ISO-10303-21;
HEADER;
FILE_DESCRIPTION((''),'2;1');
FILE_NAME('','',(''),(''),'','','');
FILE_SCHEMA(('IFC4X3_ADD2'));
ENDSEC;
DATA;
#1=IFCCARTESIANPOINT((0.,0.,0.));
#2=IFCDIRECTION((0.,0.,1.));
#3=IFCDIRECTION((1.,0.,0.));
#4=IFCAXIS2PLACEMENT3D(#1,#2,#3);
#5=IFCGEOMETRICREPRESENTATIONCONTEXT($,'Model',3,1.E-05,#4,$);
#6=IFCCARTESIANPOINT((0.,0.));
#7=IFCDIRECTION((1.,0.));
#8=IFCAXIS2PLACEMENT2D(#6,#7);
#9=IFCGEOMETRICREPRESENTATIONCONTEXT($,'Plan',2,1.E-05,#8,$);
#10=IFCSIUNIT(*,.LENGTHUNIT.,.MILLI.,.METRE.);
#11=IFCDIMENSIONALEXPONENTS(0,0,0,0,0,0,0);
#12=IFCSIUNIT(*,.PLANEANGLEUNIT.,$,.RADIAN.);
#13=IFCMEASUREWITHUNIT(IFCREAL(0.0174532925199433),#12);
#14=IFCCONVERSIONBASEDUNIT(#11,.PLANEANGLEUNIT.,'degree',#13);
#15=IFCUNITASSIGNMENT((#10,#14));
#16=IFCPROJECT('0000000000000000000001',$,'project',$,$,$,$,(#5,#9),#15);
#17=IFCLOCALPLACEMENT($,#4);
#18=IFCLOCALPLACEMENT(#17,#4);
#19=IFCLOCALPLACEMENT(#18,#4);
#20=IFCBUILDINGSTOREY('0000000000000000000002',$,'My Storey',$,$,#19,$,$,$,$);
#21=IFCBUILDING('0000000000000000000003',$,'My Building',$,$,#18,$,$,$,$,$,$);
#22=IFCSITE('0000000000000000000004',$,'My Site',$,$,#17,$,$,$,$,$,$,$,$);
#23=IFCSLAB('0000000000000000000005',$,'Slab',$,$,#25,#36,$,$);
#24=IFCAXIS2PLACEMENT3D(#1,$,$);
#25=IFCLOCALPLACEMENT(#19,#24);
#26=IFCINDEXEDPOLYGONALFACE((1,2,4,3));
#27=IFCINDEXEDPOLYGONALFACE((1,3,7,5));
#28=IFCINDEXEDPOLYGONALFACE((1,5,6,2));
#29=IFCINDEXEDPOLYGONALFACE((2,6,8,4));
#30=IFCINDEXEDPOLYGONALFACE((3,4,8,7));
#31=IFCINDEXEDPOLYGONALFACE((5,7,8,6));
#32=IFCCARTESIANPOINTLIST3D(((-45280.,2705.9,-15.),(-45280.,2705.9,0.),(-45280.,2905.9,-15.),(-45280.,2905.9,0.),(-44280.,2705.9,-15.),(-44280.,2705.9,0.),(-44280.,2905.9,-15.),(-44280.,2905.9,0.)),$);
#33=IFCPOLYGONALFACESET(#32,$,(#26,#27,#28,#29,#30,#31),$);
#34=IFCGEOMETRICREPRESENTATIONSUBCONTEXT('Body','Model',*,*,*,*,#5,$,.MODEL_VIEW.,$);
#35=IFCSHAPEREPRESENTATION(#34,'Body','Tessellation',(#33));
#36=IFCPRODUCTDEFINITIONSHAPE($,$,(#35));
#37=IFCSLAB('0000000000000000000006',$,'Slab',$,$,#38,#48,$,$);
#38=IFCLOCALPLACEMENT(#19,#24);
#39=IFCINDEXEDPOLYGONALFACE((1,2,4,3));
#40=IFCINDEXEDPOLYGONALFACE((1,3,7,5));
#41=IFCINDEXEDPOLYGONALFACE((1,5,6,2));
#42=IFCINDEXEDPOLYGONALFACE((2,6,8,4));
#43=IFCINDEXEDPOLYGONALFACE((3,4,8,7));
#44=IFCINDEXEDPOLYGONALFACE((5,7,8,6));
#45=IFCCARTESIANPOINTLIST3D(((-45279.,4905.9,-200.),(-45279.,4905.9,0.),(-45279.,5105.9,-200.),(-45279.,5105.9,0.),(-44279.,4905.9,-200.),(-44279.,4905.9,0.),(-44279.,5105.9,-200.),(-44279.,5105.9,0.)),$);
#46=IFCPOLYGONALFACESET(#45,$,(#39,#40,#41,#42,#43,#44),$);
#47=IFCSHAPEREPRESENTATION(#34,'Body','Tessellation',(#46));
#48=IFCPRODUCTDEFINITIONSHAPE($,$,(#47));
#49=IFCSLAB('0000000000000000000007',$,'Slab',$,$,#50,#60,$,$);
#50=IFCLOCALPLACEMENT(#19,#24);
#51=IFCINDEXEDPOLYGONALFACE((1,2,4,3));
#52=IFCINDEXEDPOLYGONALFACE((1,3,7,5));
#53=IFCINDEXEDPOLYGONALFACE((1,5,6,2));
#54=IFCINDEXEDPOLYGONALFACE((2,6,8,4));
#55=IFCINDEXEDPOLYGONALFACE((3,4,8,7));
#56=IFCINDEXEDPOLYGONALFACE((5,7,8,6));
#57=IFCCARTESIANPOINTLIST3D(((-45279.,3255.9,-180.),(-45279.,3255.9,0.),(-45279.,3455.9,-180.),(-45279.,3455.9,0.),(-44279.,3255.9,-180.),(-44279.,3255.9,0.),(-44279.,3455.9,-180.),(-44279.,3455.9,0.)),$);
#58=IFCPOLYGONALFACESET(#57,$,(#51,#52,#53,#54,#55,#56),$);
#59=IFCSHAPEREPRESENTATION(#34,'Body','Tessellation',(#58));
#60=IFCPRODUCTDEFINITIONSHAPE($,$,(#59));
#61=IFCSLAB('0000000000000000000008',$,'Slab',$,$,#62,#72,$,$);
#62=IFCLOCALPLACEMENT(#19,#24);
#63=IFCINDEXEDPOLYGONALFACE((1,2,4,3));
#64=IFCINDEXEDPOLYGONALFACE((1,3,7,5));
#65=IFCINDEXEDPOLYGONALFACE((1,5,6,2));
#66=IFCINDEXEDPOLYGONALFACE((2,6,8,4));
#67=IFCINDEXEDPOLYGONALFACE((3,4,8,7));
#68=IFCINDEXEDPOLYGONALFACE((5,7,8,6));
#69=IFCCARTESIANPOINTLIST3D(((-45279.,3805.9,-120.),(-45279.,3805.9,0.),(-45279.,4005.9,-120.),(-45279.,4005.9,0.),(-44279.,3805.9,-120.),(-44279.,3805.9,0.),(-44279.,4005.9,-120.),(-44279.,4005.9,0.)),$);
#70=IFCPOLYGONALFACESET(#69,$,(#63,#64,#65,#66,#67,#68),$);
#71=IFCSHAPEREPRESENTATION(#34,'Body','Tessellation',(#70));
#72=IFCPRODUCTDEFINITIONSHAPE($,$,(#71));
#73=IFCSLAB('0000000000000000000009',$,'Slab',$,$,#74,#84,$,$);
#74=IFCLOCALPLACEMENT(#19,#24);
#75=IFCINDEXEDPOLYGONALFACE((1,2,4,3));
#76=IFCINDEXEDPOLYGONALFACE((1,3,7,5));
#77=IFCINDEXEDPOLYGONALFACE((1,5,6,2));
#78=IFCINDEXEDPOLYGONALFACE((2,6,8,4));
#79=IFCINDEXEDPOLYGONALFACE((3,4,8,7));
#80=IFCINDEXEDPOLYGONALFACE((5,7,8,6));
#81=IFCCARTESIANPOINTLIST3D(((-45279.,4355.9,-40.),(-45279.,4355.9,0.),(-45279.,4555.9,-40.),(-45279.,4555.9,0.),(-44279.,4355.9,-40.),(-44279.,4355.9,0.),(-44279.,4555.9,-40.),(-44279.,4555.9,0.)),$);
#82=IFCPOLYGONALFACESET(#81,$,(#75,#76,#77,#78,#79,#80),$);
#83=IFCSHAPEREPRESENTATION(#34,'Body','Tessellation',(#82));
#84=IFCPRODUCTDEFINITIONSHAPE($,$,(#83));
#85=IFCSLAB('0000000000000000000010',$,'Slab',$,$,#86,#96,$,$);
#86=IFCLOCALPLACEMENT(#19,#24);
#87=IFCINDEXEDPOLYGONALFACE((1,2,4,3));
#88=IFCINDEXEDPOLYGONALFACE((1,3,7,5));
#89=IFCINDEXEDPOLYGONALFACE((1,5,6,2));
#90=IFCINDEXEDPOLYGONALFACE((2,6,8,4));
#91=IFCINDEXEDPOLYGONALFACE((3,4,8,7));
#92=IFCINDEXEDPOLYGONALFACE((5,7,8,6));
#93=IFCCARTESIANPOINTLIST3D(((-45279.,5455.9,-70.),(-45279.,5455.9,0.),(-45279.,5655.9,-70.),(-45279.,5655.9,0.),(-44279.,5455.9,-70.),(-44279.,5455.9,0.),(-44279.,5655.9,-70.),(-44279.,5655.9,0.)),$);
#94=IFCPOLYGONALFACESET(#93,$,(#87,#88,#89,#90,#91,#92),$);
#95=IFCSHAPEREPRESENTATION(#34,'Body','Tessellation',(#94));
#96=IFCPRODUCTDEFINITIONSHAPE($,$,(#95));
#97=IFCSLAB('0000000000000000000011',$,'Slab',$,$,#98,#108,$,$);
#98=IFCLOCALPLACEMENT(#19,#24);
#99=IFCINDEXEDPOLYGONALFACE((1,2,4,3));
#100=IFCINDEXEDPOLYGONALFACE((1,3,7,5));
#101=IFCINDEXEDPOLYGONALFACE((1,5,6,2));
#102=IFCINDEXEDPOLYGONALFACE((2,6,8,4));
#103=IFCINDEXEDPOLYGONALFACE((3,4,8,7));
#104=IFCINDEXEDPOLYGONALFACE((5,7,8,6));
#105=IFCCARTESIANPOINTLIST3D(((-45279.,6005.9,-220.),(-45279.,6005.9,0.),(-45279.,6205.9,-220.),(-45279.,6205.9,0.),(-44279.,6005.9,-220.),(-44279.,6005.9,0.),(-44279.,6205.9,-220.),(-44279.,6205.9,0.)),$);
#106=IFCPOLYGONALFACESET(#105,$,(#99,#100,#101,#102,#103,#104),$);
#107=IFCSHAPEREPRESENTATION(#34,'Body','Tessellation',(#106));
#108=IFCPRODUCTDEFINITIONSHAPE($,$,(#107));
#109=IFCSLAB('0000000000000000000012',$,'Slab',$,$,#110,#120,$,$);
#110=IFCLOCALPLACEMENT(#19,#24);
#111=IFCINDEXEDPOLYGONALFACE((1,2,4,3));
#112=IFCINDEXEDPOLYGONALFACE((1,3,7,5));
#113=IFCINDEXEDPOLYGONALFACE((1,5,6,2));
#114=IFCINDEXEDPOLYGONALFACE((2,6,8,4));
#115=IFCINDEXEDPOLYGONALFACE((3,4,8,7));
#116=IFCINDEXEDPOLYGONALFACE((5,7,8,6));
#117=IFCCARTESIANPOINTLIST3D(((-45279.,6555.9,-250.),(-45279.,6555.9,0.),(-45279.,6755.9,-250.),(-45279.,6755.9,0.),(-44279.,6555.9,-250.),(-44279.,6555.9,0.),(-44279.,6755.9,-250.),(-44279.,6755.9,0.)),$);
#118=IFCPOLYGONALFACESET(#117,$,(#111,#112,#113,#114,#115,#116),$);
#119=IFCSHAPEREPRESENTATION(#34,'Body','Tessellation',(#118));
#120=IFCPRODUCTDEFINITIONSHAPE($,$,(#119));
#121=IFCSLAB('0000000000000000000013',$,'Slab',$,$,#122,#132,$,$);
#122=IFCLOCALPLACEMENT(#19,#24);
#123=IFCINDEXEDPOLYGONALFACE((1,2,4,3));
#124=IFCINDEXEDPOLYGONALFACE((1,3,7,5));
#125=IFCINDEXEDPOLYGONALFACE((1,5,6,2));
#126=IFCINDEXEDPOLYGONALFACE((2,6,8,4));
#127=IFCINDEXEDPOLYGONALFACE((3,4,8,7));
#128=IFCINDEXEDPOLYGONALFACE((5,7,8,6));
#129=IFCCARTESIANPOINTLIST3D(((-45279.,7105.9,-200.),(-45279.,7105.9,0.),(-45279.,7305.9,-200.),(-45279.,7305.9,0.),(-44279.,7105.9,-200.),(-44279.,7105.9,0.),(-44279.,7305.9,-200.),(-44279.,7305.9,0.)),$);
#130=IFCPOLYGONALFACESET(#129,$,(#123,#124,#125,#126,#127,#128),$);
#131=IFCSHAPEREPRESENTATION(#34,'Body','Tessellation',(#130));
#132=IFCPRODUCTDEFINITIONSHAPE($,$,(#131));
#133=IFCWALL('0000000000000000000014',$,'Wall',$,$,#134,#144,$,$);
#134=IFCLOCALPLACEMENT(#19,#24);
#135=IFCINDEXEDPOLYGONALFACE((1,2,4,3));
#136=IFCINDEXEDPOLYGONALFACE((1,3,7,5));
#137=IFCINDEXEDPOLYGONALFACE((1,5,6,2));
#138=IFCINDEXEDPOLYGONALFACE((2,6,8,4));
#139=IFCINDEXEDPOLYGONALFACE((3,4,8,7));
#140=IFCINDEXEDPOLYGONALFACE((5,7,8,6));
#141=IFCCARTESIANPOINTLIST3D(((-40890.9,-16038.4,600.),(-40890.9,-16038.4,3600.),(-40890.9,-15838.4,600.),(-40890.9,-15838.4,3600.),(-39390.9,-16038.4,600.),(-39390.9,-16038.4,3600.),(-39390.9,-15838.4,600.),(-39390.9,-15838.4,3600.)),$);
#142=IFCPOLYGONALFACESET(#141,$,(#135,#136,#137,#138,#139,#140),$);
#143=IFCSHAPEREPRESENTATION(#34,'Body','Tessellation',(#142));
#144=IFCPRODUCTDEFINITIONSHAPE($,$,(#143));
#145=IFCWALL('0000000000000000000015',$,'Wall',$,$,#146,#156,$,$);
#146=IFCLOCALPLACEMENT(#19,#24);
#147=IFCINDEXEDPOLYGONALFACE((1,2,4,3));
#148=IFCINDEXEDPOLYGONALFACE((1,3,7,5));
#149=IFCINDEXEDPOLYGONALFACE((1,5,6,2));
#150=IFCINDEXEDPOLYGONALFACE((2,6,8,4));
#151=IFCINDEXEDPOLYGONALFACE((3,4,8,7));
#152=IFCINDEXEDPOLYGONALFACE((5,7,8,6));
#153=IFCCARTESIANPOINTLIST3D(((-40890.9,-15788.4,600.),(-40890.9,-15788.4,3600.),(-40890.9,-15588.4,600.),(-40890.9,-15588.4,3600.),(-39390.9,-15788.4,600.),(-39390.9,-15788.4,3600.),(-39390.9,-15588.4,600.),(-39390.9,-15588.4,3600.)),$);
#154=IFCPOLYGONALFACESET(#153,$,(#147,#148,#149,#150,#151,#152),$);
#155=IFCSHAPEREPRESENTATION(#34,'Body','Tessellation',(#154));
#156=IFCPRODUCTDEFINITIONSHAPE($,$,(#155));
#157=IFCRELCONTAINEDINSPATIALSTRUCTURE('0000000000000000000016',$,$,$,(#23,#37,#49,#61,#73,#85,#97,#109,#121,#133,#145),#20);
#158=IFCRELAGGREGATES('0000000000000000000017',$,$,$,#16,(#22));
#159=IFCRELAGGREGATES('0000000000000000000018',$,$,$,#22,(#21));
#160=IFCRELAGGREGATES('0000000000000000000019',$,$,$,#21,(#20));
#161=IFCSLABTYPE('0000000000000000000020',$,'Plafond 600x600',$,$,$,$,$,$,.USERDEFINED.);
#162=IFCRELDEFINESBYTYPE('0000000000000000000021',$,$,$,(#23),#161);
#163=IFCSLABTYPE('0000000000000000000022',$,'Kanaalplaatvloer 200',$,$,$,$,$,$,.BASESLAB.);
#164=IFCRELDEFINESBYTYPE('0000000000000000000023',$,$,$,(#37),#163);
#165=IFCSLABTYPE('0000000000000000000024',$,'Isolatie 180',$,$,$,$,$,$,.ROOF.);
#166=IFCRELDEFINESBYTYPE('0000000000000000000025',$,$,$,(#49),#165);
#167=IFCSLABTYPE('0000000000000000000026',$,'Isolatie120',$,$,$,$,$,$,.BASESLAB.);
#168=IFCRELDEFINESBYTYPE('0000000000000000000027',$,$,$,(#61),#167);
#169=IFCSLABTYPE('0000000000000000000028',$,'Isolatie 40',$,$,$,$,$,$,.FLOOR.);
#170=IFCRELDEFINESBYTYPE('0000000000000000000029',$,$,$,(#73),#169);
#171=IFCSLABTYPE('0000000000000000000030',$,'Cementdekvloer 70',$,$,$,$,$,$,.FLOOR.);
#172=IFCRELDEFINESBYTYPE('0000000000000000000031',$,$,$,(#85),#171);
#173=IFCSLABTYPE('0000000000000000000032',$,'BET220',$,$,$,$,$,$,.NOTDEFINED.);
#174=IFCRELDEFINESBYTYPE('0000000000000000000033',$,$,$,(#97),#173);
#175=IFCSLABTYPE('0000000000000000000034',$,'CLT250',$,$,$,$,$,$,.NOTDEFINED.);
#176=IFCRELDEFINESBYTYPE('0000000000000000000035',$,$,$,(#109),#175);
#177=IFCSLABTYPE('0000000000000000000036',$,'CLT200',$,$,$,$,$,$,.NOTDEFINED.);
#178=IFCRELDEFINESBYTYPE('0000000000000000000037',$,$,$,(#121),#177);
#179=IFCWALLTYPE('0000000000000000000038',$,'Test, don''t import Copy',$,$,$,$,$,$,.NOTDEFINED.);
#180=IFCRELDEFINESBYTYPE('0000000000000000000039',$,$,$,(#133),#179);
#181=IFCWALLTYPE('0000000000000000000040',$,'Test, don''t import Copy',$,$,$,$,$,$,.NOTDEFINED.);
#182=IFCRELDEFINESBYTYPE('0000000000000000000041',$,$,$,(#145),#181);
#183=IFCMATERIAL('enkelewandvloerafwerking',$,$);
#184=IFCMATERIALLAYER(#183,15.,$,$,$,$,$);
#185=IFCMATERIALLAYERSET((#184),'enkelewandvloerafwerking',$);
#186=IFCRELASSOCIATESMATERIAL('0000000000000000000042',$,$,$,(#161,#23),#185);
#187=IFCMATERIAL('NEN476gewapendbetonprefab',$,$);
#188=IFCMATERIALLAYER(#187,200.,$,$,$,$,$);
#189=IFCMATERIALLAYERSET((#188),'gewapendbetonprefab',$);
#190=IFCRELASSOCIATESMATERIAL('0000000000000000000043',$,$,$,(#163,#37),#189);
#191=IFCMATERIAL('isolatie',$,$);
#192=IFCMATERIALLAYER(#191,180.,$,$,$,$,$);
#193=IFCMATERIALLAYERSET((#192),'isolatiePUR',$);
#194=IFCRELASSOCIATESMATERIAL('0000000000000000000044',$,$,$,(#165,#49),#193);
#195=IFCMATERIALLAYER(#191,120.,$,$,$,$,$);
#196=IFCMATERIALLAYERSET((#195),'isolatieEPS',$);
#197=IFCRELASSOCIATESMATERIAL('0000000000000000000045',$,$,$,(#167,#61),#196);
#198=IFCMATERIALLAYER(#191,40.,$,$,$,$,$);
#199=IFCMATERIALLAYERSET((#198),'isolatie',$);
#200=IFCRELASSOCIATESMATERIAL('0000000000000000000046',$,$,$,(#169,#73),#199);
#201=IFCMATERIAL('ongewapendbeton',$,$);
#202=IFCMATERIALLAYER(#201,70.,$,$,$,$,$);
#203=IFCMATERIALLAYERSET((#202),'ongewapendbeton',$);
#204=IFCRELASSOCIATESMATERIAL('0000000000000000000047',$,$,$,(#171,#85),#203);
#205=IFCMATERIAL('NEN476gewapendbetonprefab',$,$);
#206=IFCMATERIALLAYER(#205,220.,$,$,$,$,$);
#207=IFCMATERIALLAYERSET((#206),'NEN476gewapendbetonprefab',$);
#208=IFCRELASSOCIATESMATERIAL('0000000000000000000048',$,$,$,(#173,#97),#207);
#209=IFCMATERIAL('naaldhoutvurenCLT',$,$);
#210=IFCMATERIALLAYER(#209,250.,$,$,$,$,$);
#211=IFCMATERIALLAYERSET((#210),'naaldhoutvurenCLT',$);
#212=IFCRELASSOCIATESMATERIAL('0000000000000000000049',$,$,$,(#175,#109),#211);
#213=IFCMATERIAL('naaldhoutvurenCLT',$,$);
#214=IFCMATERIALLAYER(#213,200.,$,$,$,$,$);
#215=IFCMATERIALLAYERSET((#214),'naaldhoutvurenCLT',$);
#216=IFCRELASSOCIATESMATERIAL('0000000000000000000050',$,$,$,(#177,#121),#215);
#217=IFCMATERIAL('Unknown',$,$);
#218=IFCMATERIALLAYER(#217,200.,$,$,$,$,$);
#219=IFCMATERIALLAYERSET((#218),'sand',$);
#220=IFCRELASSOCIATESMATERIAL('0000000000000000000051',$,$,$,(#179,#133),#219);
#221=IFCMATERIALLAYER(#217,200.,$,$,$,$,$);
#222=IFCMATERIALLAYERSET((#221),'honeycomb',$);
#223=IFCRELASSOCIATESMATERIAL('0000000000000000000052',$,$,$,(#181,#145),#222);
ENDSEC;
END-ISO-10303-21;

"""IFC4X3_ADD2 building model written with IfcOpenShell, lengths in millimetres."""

from ifc_helpers import new_model, entity, si_unit, converted_unit, frame, origin_with_axes, origin_2d_with_axis, place, context, subcontext, project, spatial, line, indexed_curve, outline, extrude, material, layer, layer_set, layer_usage, type_object, element, save


model = new_model("IFC4X3_ADD2")

# Units and contexts
model_context = context("Model", 3, precision=1e-05, world=origin_with_axes())
plan_context = context("Plan", 2, precision=1e-05, world=origin_2d_with_axis())
body_context = subcontext(model_context, "Body", "Model", "MODEL_VIEW")
ifc_project = project(units=[si_unit("LENGTHUNIT", "METRE", prefix="MILLI"), converted_unit("PLANEANGLEUNIT", "degree", entity("IfcReal", 0.0174532925199433), si_unit("PLANEANGLEUNIT", "RADIAN"), dimensions=[0, 0, 0, 0, 0, 0, 0])], contexts=[model_context, plan_context])

# Site, building, storey
site_placement = place(None, origin_with_axes())
site = spatial("IfcSite", under=ifc_project, at=site_placement, Name="My Site")
building_placement = place(site_placement, origin_with_axes())
building = spatial("IfcBuilding", under=site, at=building_placement, Name="My Building")
storey_placement = place(building_placement, origin_with_axes())
storey = spatial("IfcBuildingStorey", under=building, at=storey_placement, Name="My Storey")

# Shared definitions
ifc_material_1 = material(Name="naaldhoutvurenCLT")

# Shared definitions
ifc_material_2 = material(Name="NEN476gewapendbetonprefab")

# Slabs
ifc_material_3 = material(Name="enkelewandvloerafwerking")
ifc_layer_1 = layer(ifc_material_3, 15.0)
ifc_layer_set_1 = layer_set([ifc_layer_1], Name="enkelewandvloerafwerking")
ifc_layer_usage_1 = layer_usage(ifc_layer_set_1, "AXIS3", "POSITIVE", 0.0)
slab_type_1 = type_object("IfcSlabType", Name="Plafond 600x600", PredefinedType="USERDEFINED", material=ifc_layer_set_1)
slab_1_placement = place(storey_placement, frame((-45280.0, 2705.9, -15.0), z_axis=(0.0, 0.0, 1.0), x_axis=(1.0, 0.0, 0.0)))
element("IfcSlab", 1, at=slab_1_placement, inside=storey, type_object=slab_type_1, material=ifc_layer_usage_1, Name="Slab", context=body_context, shape_type="SweptSolid", body=[
    extrude(outline(indexed_curve([(1000.0, 200.0), (1000.0, 0.0), (0.0, 0.0), (0.0, 200.0)], segments=[line(4, 1), line(1, 2), line(2, 3), line(3, 4)], self_intersect=False)), None, (0.0, 0.0, 1.0), 15.0),
])
ifc_layer_2 = layer(ifc_material_2, 200.0)
ifc_layer_set_2 = layer_set([ifc_layer_2], Name="gewapendbetonprefab")
ifc_layer_usage_2 = layer_usage(ifc_layer_set_2, "AXIS3", "POSITIVE", 0.0)
slab_type_2 = type_object("IfcSlabType", Name="Kanaalplaatvloer 200", PredefinedType="BASESLAB", material=ifc_layer_set_2)
slab_2_placement = place(storey_placement, frame((-45279.0, 4905.9, -200.0), z_axis=(0.0, 0.0, 1.0), x_axis=(1.0, 0.0, 0.0)))
element("IfcSlab", 2, at=slab_2_placement, inside=storey, type_object=slab_type_2, material=ifc_layer_usage_2, Name="Slab", context=body_context, shape_type="SweptSolid", body=[
    extrude(outline(indexed_curve([(1000.0, 200.0), (1000.0, 0.0), (0.0, 0.0), (0.0, 200.0)], segments=[line(4, 1), line(1, 2), line(2, 3), line(3, 4)], self_intersect=False)), None, (0.0, 0.0, 1.0), 200.0),
])
ifc_material_4 = material(Name="isolatie")
ifc_layer_3 = layer(ifc_material_4, 180.0)
ifc_layer_set_3 = layer_set([ifc_layer_3], Name="isolatiePUR")
ifc_layer_usage_3 = layer_usage(ifc_layer_set_3, "AXIS3", "POSITIVE", 0.0)
slab_type_3 = type_object("IfcSlabType", Name="Isolatie 180", PredefinedType="ROOF", material=ifc_layer_set_3)
slab_3_placement = place(storey_placement, frame((-45279.0, 3255.9, -180.0), z_axis=(0.0, 0.0, 1.0), x_axis=(1.0, 0.0, 0.0)))
element("IfcSlab", 3, at=slab_3_placement, inside=storey, type_object=slab_type_3, material=ifc_layer_usage_3, Name="Slab", context=body_context, shape_type="SweptSolid", body=[
    extrude(outline(indexed_curve([(1000.0, 200.0), (1000.0, 0.0), (0.0, 0.0), (0.0, 200.0)], segments=[line(4, 1), line(1, 2), line(2, 3), line(3, 4)], self_intersect=False)), None, (0.0, 0.0, 1.0), 180.0),
])
ifc_layer_4 = layer(ifc_material_4, 120.0)
ifc_layer_set_4 = layer_set([ifc_layer_4], Name="isolatieEPS")
ifc_layer_usage_4 = layer_usage(ifc_layer_set_4, "AXIS3", "POSITIVE", 0.0)
slab_type_4 = type_object("IfcSlabType", Name="Isolatie120", PredefinedType="BASESLAB", material=ifc_layer_set_4)
slab_4_placement = place(storey_placement, frame((-45279.0, 3805.9, -120.0), z_axis=(0.0, 0.0, 1.0), x_axis=(1.0, 0.0, 0.0)))
element("IfcSlab", 4, at=slab_4_placement, inside=storey, type_object=slab_type_4, material=ifc_layer_usage_4, Name="Slab", context=body_context, shape_type="SweptSolid", body=[
    extrude(outline(indexed_curve([(1000.0, 200.0), (1000.0, 0.0), (0.0, 0.0), (0.0, 200.0)], segments=[line(3, 2), line(2, 1), line(1, 4), line(4, 3)], self_intersect=False)), None, (0.0, 0.0, 1.0), 120.0),
])
ifc_layer_5 = layer(ifc_material_4, 40.0)
ifc_layer_set_5 = layer_set([ifc_layer_5], Name="isolatie")
ifc_layer_usage_5 = layer_usage(ifc_layer_set_5, "AXIS3", "POSITIVE", 0.0)
slab_type_5 = type_object("IfcSlabType", Name="Isolatie 40", PredefinedType="FLOOR", material=ifc_layer_set_5)
slab_5_placement = place(storey_placement, frame((-45279.0, 4355.9, -40.0), z_axis=(0.0, 0.0, 1.0), x_axis=(1.0, 0.0, 0.0)))
element("IfcSlab", 5, at=slab_5_placement, inside=storey, type_object=slab_type_5, material=ifc_layer_usage_5, Name="Slab", context=body_context, shape_type="SweptSolid", body=[
    extrude(outline(indexed_curve([(1000.0, 200.0), (1000.0, 0.0), (0.0, 0.0), (0.0, 200.0)], segments=[line(3, 2), line(2, 1), line(1, 4), line(4, 3)], self_intersect=False)), None, (0.0, 0.0, 1.0), 40.0),
])
ifc_material_5 = material(Name="ongewapendbeton")
ifc_layer_6 = layer(ifc_material_5, 70.0)
ifc_layer_set_6 = layer_set([ifc_layer_6], Name="ongewapendbeton")
ifc_layer_usage_6 = layer_usage(ifc_layer_set_6, "AXIS3", "POSITIVE", 0.0)
slab_type_6 = type_object("IfcSlabType", Name="Cementdekvloer 70", PredefinedType="FLOOR", material=ifc_layer_set_6)
slab_6_placement = place(storey_placement, frame((-45279.0, 5455.9, -70.0), z_axis=(0.0, 0.0, 1.0), x_axis=(1.0, 0.0, 0.0)))
element("IfcSlab", 6, at=slab_6_placement, inside=storey, type_object=slab_type_6, material=ifc_layer_usage_6, Name="Slab", context=body_context, shape_type="SweptSolid", body=[
    extrude(outline(indexed_curve([(1000.0, 200.0), (1000.0, 0.0), (0.0, 0.0), (0.0, 200.0)], segments=[line(4, 1), line(1, 2), line(2, 3), line(3, 4)], self_intersect=False)), None, (0.0, 0.0, 1.0), 70.0),
])
ifc_material_6 = material(Name="NEN476gewapendbetonprefab")
ifc_layer_7 = layer(ifc_material_6, 220.0)
ifc_layer_set_7 = layer_set([ifc_layer_7], Name="NEN476gewapendbetonprefab")
ifc_layer_usage_7 = layer_usage(ifc_layer_set_7, "AXIS3", "POSITIVE", 0.0)
slab_type_7 = type_object("IfcSlabType", Name="BET220", PredefinedType="NOTDEFINED", material=ifc_layer_set_7)
slab_7_placement = place(storey_placement, frame((-45279.0, 6005.9, -220.0), z_axis=(0.0, 0.0, 1.0), x_axis=(1.0, 0.0, 0.0)))
element("IfcSlab", 7, at=slab_7_placement, inside=storey, type_object=slab_type_7, material=ifc_layer_usage_7, Name="Slab", context=body_context, shape_type="SweptSolid", body=[
    extrude(outline(indexed_curve([(1000.0, 200.0), (1000.0, 0.0), (0.0, 0.0), (0.0, 200.0)], segments=[line(4, 1), line(1, 2), line(2, 3), line(3, 4)], self_intersect=False)), None, (0.0, 0.0, 1.0), 220.0),
])
ifc_material_7 = material(Name="naaldhoutvurenCLT")
ifc_layer_8 = layer(ifc_material_7, 250.0)
ifc_layer_set_8 = layer_set([ifc_layer_8], Name="naaldhoutvurenCLT")
ifc_layer_usage_8 = layer_usage(ifc_layer_set_8, "AXIS3", "POSITIVE", 0.0)
slab_type_8 = type_object("IfcSlabType", Name="CLT250", PredefinedType="NOTDEFINED", material=ifc_layer_set_8)
slab_8_placement = place(storey_placement, frame((-45279.0, 6555.9, -250.0), z_axis=(0.0, 0.0, 1.0), x_axis=(1.0, 0.0, 0.0)))
element("IfcSlab", 8, at=slab_8_placement, inside=storey, type_object=slab_type_8, material=ifc_layer_usage_8, Name="Slab", context=body_context, shape_type="SweptSolid", body=[
    extrude(outline(indexed_curve([(1000.0, 200.0), (1000.0, 0.0), (0.0, 0.0), (0.0, 200.0)], segments=[line(3, 2), line(2, 1), line(1, 4), line(4, 3)], self_intersect=False)), None, (0.0, 0.0, 1.0), 250.0),
])
ifc_layer_9 = layer(ifc_material_1, 200.0)
ifc_layer_set_9 = layer_set([ifc_layer_9], Name="naaldhoutvurenCLT")
ifc_layer_usage_9 = layer_usage(ifc_layer_set_9, "AXIS3", "POSITIVE", 0.0)
slab_type_9 = type_object("IfcSlabType", Name="CLT200", PredefinedType="NOTDEFINED", material=ifc_layer_set_9)
slab_9_placement = place(storey_placement, frame((-45279.0, 7105.9, -200.0), z_axis=(0.0, 0.0, 1.0), x_axis=(1.0, 0.0, 0.0)))
element("IfcSlab", 9, at=slab_9_placement, inside=storey, type_object=slab_type_9, material=ifc_layer_usage_9, Name="Slab", context=body_context, shape_type="SweptSolid", body=[
    extrude(outline(indexed_curve([(1000.0, 200.0), (1000.0, 0.0), (0.0, 0.0), (0.0, 200.0)], segments=[line(3, 2), line(2, 1), line(1, 4), line(4, 3)], self_intersect=False)), None, (0.0, 0.0, 1.0), 200.0),
])

# Walls
ifc_material_8 = material(Name="Unknown")
ifc_layer_10 = layer(ifc_material_8, 200.0)
ifc_layer_set_10 = layer_set([ifc_layer_10], Name="sand")
ifc_layer_usage_10 = layer_usage(ifc_layer_set_10, "AXIS2", "POSITIVE", 0.0)
wall_type_1 = type_object("IfcWallType", Name="Test, don't import Copy", PredefinedType="NOTDEFINED", material=ifc_layer_set_10)
wall_1_placement = place(storey_placement, frame((-40890.9, -16038.4, 600.0), z_axis=(0.0, 0.0, 1.0), x_axis=(1.0, 0.0, 0.0)))
element("IfcWall", 10, at=wall_1_placement, inside=storey, type_object=wall_type_1, material=ifc_layer_usage_10, Name="Wall", context=body_context, shape_type="SweptSolid", body=[
    extrude(outline(indexed_curve([(0.0, 0.0), (0.0, 200.0), (1500.0, 200.0), (1500.0, 0.0), (0.0, 0.0)], self_intersect=False)), origin_with_axes(), (0.0, 0.0, 1.0), 3000.0),
])
ifc_layer_11 = layer(ifc_material_8, 200.0)
ifc_layer_set_11 = layer_set([ifc_layer_11], Name="honeycomb")
ifc_layer_usage_11 = layer_usage(ifc_layer_set_11, "AXIS2", "POSITIVE", 0.0)
wall_type_2 = type_object("IfcWallType", Name="Test, don't import Copy", PredefinedType="NOTDEFINED", material=ifc_layer_set_11)
wall_2_placement = place(storey_placement, frame((-40890.9, -15788.4, 600.0), z_axis=(0.0, 0.0, 1.0), x_axis=(1.0, 0.0, 0.0)))
element("IfcWall", 11, at=wall_2_placement, inside=storey, type_object=wall_type_2, material=ifc_layer_usage_11, Name="Wall", context=body_context, shape_type="SweptSolid", body=[
    extrude(outline(indexed_curve([(0.0, 0.0), (0.0, 200.0), (1500.0, 200.0), (1500.0, 0.0), (0.0, 0.0)], self_intersect=False)), origin_with_axes(), (0.0, 0.0, 1.0), 3000.0),
])

save(model, "model.ifc")
